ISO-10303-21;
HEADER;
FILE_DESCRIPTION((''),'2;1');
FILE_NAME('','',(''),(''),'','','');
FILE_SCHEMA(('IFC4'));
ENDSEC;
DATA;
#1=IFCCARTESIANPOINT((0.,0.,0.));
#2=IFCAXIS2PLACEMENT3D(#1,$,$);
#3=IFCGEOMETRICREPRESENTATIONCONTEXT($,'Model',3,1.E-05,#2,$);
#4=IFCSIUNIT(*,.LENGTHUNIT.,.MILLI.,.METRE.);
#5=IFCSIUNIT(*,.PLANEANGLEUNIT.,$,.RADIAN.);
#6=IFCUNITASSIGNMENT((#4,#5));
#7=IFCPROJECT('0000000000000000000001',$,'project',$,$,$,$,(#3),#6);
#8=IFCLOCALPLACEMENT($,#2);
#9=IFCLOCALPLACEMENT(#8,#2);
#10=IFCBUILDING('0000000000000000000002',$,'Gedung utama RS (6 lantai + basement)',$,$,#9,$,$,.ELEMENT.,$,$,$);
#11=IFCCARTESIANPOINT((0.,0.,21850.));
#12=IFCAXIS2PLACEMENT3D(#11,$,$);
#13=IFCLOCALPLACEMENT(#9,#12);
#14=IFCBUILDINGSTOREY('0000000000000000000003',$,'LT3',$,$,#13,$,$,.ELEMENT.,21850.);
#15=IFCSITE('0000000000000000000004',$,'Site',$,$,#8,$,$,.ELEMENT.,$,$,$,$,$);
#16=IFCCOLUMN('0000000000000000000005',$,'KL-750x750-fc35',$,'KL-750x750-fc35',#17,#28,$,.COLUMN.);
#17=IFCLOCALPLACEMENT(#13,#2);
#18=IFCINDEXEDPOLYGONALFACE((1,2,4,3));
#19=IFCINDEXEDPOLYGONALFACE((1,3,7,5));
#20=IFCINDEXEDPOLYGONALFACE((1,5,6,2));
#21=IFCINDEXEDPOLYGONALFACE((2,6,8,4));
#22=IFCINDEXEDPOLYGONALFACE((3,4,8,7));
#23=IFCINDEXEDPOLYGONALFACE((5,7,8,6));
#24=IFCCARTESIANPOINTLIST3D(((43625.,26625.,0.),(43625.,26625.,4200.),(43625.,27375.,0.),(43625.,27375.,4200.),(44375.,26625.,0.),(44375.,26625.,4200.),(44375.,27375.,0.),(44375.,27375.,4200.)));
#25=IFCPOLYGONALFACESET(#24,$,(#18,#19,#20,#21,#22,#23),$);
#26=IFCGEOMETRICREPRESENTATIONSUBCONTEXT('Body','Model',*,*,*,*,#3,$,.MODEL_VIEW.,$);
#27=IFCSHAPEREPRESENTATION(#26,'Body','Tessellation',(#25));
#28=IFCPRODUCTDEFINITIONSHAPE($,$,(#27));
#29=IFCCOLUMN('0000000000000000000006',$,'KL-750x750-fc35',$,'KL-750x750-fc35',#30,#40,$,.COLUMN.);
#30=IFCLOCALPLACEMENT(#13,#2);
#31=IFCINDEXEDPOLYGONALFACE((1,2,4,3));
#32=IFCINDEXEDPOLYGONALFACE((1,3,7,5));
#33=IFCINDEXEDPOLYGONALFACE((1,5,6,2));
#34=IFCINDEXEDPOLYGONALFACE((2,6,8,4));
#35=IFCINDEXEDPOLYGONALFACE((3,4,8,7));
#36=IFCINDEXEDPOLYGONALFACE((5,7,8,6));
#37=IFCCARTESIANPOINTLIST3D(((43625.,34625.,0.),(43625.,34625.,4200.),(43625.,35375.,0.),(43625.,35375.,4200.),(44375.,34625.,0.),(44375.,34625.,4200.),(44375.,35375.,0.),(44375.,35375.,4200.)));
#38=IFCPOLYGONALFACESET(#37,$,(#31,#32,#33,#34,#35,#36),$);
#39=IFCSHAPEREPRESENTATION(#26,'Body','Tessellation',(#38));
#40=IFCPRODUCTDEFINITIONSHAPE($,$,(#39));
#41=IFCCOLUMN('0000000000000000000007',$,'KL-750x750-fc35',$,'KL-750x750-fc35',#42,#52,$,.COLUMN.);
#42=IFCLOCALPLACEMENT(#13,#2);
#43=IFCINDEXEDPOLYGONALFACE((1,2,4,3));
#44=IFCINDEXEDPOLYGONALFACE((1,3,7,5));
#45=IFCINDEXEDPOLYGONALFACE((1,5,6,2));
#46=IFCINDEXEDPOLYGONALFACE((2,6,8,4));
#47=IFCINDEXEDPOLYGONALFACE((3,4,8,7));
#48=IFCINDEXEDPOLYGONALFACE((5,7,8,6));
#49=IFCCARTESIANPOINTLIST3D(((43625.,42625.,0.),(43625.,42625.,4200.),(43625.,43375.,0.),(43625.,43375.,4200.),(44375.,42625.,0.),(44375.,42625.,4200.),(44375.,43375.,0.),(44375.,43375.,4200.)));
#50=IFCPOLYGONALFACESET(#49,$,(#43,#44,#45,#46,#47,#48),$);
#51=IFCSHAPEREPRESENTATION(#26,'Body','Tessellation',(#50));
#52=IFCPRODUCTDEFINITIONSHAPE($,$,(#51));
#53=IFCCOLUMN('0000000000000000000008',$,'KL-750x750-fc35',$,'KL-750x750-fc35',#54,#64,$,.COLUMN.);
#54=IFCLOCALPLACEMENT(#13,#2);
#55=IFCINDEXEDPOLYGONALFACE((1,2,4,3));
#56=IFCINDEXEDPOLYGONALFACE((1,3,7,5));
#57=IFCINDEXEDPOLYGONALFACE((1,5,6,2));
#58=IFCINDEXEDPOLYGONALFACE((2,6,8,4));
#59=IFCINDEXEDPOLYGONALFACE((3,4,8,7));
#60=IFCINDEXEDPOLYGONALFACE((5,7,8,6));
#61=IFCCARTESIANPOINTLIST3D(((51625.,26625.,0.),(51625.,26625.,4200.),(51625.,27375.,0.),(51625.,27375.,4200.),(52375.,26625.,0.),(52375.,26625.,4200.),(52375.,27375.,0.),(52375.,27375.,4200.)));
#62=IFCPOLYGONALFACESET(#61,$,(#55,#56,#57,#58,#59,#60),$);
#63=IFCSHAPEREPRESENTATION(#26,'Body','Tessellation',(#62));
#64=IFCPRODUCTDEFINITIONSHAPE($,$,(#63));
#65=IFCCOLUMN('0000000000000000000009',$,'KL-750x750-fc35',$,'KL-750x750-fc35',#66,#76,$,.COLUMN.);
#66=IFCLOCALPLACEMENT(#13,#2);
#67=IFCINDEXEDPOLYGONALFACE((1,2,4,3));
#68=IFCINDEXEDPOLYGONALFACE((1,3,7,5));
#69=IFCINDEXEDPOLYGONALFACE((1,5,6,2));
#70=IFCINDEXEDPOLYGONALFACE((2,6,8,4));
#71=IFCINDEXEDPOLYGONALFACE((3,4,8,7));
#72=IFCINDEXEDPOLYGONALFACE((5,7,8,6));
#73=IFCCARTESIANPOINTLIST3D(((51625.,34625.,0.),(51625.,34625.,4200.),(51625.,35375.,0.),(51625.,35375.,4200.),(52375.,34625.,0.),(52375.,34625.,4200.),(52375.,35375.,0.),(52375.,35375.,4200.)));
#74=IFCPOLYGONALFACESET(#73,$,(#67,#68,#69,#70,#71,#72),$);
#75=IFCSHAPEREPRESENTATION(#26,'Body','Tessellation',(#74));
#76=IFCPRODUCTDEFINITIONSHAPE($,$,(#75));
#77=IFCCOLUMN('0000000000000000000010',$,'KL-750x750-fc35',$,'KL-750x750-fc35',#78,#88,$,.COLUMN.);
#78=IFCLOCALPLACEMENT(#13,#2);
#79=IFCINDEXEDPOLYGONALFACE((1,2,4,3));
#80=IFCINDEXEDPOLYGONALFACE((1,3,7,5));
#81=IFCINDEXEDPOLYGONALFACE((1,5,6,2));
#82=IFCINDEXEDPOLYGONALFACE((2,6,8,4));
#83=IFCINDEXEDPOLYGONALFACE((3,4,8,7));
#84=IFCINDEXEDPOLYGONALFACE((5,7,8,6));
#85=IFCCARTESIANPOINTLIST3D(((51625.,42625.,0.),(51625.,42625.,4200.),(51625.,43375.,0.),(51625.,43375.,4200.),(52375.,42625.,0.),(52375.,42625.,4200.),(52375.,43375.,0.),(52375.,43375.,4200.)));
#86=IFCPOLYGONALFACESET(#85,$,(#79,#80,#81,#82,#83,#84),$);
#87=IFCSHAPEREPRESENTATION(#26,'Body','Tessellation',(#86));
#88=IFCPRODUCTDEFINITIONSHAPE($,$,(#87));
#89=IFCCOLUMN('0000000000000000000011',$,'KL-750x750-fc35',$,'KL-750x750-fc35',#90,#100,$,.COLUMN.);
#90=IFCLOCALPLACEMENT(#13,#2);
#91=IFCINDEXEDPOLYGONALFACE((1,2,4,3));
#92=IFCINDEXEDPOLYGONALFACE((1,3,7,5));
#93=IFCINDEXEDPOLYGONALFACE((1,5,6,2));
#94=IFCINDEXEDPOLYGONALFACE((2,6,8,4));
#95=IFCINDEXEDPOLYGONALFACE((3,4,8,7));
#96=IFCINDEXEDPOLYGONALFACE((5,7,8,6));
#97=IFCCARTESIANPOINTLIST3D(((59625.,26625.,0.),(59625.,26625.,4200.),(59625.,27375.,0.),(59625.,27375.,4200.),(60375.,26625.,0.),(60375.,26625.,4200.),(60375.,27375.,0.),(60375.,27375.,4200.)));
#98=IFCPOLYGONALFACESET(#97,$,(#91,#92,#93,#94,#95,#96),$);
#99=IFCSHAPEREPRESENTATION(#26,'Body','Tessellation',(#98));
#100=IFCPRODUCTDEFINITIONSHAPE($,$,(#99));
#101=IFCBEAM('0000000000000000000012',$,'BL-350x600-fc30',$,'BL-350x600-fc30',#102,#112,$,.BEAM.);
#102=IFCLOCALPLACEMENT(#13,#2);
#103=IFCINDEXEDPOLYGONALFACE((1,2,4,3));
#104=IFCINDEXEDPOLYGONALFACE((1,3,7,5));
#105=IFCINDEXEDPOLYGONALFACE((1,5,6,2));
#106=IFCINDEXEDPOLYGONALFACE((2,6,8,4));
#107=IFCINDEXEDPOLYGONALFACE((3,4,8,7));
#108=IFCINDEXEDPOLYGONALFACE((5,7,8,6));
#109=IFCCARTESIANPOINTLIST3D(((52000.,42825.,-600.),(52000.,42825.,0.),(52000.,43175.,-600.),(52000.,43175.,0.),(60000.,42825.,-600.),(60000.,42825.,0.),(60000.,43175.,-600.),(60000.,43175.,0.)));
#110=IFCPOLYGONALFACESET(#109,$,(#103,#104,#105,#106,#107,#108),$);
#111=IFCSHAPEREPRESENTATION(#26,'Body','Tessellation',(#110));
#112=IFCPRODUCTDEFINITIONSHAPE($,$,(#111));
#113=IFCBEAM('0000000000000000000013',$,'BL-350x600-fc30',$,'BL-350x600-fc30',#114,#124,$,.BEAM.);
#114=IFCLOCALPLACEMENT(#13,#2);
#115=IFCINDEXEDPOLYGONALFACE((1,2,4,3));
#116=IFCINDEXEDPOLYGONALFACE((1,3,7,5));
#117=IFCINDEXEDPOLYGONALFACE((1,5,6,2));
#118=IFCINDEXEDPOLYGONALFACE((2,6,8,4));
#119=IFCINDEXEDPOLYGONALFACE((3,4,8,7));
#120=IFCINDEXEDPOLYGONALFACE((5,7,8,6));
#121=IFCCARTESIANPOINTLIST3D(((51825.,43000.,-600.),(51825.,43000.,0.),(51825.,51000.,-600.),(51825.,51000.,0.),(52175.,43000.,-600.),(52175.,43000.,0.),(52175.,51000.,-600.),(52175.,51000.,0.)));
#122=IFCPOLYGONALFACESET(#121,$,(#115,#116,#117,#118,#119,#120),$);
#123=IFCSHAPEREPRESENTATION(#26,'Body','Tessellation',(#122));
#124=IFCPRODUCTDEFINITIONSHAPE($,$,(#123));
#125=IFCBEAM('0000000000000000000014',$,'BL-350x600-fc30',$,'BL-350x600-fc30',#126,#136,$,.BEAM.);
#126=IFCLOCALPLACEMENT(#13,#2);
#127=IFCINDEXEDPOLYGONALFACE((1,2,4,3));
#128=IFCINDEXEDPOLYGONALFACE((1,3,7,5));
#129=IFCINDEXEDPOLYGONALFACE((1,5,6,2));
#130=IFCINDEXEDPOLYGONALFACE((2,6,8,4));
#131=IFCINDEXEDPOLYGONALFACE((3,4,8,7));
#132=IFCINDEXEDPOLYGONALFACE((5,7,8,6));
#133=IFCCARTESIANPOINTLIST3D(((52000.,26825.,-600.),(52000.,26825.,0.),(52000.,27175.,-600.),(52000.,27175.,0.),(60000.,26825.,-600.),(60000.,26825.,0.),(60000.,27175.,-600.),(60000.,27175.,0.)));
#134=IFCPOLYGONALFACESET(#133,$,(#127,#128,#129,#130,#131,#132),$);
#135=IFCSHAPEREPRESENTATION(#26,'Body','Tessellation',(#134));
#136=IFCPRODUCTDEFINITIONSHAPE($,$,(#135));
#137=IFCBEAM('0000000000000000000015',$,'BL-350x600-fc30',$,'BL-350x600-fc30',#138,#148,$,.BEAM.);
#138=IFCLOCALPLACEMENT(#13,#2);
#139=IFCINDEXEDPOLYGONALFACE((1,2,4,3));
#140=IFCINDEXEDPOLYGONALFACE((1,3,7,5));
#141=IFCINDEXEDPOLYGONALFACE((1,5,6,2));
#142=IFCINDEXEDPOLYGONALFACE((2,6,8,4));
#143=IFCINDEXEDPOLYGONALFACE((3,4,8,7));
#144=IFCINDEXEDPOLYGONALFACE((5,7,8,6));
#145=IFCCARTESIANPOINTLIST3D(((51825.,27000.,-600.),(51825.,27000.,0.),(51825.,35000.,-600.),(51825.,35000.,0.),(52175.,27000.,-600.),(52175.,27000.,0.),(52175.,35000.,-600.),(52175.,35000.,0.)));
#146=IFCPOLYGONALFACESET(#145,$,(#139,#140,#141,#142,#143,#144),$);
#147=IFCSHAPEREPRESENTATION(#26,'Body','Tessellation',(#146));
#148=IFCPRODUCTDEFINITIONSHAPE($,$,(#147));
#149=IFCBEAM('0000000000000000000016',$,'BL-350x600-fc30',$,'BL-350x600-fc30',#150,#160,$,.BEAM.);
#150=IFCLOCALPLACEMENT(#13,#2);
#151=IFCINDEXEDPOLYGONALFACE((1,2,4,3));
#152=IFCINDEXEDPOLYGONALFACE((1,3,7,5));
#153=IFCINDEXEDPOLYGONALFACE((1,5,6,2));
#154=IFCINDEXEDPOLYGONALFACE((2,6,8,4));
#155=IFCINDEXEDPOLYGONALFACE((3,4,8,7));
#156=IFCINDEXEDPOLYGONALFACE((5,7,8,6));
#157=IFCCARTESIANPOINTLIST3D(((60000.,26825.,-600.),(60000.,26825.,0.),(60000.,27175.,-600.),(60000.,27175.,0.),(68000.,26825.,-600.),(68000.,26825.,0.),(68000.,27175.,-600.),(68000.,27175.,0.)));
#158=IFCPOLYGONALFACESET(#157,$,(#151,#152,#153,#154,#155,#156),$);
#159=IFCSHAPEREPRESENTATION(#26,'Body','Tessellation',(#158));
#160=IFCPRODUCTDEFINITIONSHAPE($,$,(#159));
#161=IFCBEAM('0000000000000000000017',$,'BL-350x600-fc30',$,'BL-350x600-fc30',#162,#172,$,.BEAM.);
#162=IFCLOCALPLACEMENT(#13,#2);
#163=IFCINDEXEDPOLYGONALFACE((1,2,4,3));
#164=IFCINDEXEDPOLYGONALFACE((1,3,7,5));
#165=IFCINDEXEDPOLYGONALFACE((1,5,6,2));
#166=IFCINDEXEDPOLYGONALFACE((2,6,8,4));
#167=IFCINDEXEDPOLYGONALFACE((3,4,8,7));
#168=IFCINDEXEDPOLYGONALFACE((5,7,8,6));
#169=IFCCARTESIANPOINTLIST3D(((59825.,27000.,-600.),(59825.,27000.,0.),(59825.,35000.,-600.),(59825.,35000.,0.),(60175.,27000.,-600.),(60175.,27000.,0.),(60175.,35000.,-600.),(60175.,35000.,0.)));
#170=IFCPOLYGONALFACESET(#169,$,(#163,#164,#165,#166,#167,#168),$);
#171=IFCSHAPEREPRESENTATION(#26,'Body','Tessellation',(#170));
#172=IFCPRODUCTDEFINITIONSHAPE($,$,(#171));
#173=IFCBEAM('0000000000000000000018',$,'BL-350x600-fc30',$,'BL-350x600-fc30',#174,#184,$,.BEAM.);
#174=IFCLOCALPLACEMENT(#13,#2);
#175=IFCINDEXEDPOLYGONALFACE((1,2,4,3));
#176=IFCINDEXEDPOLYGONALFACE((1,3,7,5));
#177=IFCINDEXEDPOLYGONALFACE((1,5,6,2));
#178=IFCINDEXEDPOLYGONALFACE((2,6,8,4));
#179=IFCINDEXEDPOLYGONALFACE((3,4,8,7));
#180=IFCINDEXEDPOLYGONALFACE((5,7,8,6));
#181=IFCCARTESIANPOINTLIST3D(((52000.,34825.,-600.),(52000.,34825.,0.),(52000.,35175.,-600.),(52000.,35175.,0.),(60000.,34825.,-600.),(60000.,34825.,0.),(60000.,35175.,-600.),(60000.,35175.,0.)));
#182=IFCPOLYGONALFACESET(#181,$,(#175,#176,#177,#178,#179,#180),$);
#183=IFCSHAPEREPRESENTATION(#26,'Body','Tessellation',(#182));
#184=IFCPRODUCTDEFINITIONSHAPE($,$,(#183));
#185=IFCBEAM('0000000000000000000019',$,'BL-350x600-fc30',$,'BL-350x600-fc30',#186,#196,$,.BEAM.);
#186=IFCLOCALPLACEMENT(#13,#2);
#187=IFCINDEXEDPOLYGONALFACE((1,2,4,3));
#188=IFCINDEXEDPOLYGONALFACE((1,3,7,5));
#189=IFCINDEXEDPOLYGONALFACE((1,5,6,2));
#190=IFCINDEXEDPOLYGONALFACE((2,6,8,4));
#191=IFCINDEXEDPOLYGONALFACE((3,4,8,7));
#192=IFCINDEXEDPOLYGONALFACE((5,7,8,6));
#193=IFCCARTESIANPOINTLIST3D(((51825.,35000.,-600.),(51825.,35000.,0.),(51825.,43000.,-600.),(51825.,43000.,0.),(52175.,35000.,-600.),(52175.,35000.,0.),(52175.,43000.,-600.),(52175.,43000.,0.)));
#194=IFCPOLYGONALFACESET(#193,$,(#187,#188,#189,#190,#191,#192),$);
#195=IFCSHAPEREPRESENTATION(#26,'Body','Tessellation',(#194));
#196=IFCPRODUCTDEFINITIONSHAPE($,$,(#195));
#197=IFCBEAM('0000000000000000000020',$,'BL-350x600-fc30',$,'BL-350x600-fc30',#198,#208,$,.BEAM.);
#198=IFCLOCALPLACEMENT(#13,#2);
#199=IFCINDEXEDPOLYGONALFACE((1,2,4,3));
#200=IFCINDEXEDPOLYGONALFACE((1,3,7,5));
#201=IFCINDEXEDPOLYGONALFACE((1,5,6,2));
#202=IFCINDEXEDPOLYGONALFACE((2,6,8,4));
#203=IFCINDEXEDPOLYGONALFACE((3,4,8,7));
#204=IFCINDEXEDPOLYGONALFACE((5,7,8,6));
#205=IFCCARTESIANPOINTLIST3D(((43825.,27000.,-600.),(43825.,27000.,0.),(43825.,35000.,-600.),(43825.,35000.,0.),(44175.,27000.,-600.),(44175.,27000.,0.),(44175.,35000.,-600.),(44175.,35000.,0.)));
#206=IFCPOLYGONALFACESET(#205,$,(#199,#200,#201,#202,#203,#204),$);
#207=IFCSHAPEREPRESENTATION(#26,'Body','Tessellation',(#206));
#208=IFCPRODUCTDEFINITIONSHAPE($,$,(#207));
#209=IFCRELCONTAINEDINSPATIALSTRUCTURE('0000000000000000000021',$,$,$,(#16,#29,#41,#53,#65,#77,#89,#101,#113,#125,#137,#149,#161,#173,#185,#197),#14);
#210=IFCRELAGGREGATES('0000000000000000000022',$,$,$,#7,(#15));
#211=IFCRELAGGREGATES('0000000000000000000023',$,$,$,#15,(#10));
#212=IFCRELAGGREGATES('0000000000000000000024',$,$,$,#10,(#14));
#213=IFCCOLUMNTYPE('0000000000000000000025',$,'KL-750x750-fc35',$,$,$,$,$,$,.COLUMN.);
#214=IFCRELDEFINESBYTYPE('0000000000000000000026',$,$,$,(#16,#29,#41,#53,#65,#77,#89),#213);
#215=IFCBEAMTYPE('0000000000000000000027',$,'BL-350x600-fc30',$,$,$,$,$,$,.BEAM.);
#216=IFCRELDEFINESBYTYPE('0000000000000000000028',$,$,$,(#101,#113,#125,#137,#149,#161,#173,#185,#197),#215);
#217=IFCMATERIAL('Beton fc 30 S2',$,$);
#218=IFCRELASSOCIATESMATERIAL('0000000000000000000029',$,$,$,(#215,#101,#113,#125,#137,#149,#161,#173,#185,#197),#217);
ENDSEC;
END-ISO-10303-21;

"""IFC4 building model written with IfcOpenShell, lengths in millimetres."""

from ifc_helpers import new_model, si_unit, frame, origin, origin_2d, place, context, subcontext, project, spatial, rectangle, extrude, material, material_profile, profile_set, profile_usage, type_object, element, save


model = new_model("IFC4")

# Units and contexts
model_context = context("Model", 3, precision=1e-05, world=origin())
body_context = subcontext(model_context, "Body", "Model", "MODEL_VIEW")
ifc_project = project(units=[si_unit("LENGTHUNIT", "METRE", prefix="MILLI"), si_unit("PLANEANGLEUNIT", "RADIAN")], contexts=[model_context])

# Site, building, storey
site_placement = place(None, origin())
site = spatial("IfcSite", under=ifc_project, at=site_placement, Name="Site", CompositionType="ELEMENT")
building_placement = place(site_placement, origin())
building = spatial("IfcBuilding", under=site, at=building_placement, Name="Gedung utama RS (6 lantai + basement)", CompositionType="ELEMENT")
storey_placement = place(building_placement, frame((0.0, 0.0, 21850.0)))
storey = spatial("IfcBuildingStorey", under=building, at=storey_placement, Name="LT3", CompositionType="ELEMENT", Elevation=21850.0)

# Columns
ifc_material_profile_1 = material_profile(None, rectangle(XDim=750.0, YDim=750.0, at=origin_2d()), Name="KL-750x750-fc35")
ifc_profile_set_1 = profile_set([ifc_material_profile_1], Name="KL-750x750-fc35")
ifc_profile_usage_1 = profile_usage(ifc_profile_set_1, cardinal=5)
column_type = type_object("IfcColumnType", Name="KL-750x750-fc35", PredefinedType="COLUMN", material=ifc_profile_set_1)
for number, where, z_axis, x_axis, name in (
    (1, (44000.0, 27000.0, 0.0), (0.0, 0.0, 1.0), (1.0, 0.0, 0.0), "KL-750x750-fc35"),
    (2, (44000.0, 35000.0, 0.0), (0.0, 0.0, 1.0), (1.0, 0.0, 0.0), "KL-750x750-fc35"),
    (3, (44000.0, 43000.0, 0.0), (0.0, 0.0, 1.0), (1.0, 0.0, 0.0), "KL-750x750-fc35"),
    (4, (52000.0, 27000.0, 0.0), (0.0, 0.0, 1.0), (1.0, 0.0, 0.0), "KL-750x750-fc35"),
    (5, (52000.0, 35000.0, 0.0), (0.0, 0.0, 1.0), (1.0, 0.0, 0.0), "KL-750x750-fc35"),
    (6, (52000.0, 43000.0, 0.0), (0.0, 0.0, 1.0), (1.0, 0.0, 0.0), "KL-750x750-fc35"),
    (7, (60000.0, 27000.0, 0.0), (0.0, 0.0, 1.0), (1.0, 0.0, 0.0), "KL-750x750-fc35"),
):
    element("IfcColumn", number, at=place(storey_placement, frame(where, z_axis=z_axis, x_axis=x_axis)), inside=storey, type_object=column_type, material=ifc_profile_usage_1, Name=name, ObjectType="KL-750x750-fc35", PredefinedType="COLUMN", context=body_context, shape_type="SweptSolid", body=[
        extrude(rectangle(XDim=750.0, YDim=750.0, at=origin_2d()), origin(), (0.0, 0.0, 1.0), 4200.0),
    ])

# Beams
ifc_material_1 = material(Name="Beton fc 30 S2")
ifc_material_profile_2 = material_profile(ifc_material_1, rectangle(XDim=350.0, YDim=600.0, at=origin_2d()), Name="BL-350x600-fc30")
ifc_profile_set_2 = profile_set([ifc_material_profile_2], Name="BL-350x600-fc30")
ifc_profile_usage_2 = profile_usage(ifc_profile_set_2, cardinal=8)
beam_type = type_object("IfcBeamType", Name="BL-350x600-fc30", PredefinedType="BEAM", material=ifc_profile_set_2)
beam_1_placement = place(storey_placement, frame((52000.0, 43000.0, -300.0)))
element("IfcBeam", 8, at=beam_1_placement, inside=storey, type_object=beam_type, material=ifc_profile_usage_2, Name="BL-350x600-fc30", ObjectType="BL-350x600-fc30", PredefinedType="BEAM", context=body_context, shape_type="SweptSolid", body=[
    extrude(rectangle(XDim=350.0, YDim=600.0, at=origin_2d()), frame((0.0, 0.0, 0.0), z_axis=(1.0, 0.0, 0.0), x_axis=(0.0, 1.0, 0.0)), (0.0, 0.0, 1.0), 8000.0),
])
beam_2_placement = place(storey_placement, frame((52000.0, 43000.0, -300.0)))
element("IfcBeam", 9, at=beam_2_placement, inside=storey, type_object=beam_type, material=ifc_profile_usage_2, Name="BL-350x600-fc30", ObjectType="BL-350x600-fc30", PredefinedType="BEAM", context=body_context, shape_type="SweptSolid", body=[
    extrude(rectangle(XDim=350.0, YDim=600.0, at=origin_2d()), frame((0.0, 0.0, 0.0), z_axis=(0.0, 1.0, 0.0), x_axis=(-1.0, 0.0, 0.0)), (0.0, 0.0, 1.0), 8000.0),
])
beam_3_placement = place(storey_placement, frame((52000.0, 27000.0, -300.0)))
element("IfcBeam", 10, at=beam_3_placement, inside=storey, type_object=beam_type, material=ifc_profile_usage_2, Name="BL-350x600-fc30", ObjectType="BL-350x600-fc30", PredefinedType="BEAM", context=body_context, shape_type="SweptSolid", body=[
    extrude(rectangle(XDim=350.0, YDim=600.0, at=origin_2d()), frame((0.0, 0.0, 0.0), z_axis=(1.0, 0.0, 0.0), x_axis=(0.0, 1.0, 0.0)), (0.0, 0.0, 1.0), 8000.0),
])
beam_4_placement = place(storey_placement, frame((52000.0, 27000.0, -300.0)))
element("IfcBeam", 11, at=beam_4_placement, inside=storey, type_object=beam_type, material=ifc_profile_usage_2, Name="BL-350x600-fc30", ObjectType="BL-350x600-fc30", PredefinedType="BEAM", context=body_context, shape_type="SweptSolid", body=[
    extrude(rectangle(XDim=350.0, YDim=600.0, at=origin_2d()), frame((0.0, 0.0, 0.0), z_axis=(0.0, 1.0, 0.0), x_axis=(-1.0, 0.0, 0.0)), (0.0, 0.0, 1.0), 8000.0),
])
beam_5_placement = place(storey_placement, frame((60000.0, 27000.0, -300.0)))
element("IfcBeam", 12, at=beam_5_placement, inside=storey, type_object=beam_type, material=ifc_profile_usage_2, Name="BL-350x600-fc30", ObjectType="BL-350x600-fc30", PredefinedType="BEAM", context=body_context, shape_type="SweptSolid", body=[
    extrude(rectangle(XDim=350.0, YDim=600.0, at=origin_2d()), frame((0.0, 0.0, 0.0), z_axis=(1.0, 0.0, 0.0), x_axis=(0.0, 1.0, 0.0)), (0.0, 0.0, 1.0), 8000.0),
])
beam_6_placement = place(storey_placement, frame((60000.0, 27000.0, -300.0)))
element("IfcBeam", 13, at=beam_6_placement, inside=storey, type_object=beam_type, material=ifc_profile_usage_2, Name="BL-350x600-fc30", ObjectType="BL-350x600-fc30", PredefinedType="BEAM", context=body_context, shape_type="SweptSolid", body=[
    extrude(rectangle(XDim=350.0, YDim=600.0, at=origin_2d()), frame((0.0, 0.0, 0.0), z_axis=(0.0, 1.0, 0.0), x_axis=(-1.0, 0.0, 0.0)), (0.0, 0.0, 1.0), 8000.0),
])
beam_7_placement = place(storey_placement, frame((52000.0, 35000.0, -300.0)))
element("IfcBeam", 14, at=beam_7_placement, inside=storey, type_object=beam_type, material=ifc_profile_usage_2, Name="BL-350x600-fc30", ObjectType="BL-350x600-fc30", PredefinedType="BEAM", context=body_context, shape_type="SweptSolid", body=[
    extrude(rectangle(XDim=350.0, YDim=600.0, at=origin_2d()), frame((0.0, 0.0, 0.0), z_axis=(1.0, 0.0, 0.0), x_axis=(0.0, 1.0, 0.0)), (0.0, 0.0, 1.0), 8000.0),
])
for number, where, name in (
    (15, (52000.0, 35000.0, -300.0), "BL-350x600-fc30"),
    (16, (44000.0, 27000.0, -300.0), "BL-350x600-fc30"),
):
    element("IfcBeam", number, at=place(storey_placement, frame(where)), inside=storey, type_object=beam_type, material=ifc_profile_usage_2, Name=name, ObjectType="BL-350x600-fc30", PredefinedType="BEAM", context=body_context, shape_type="SweptSolid", body=[
        extrude(rectangle(XDim=350.0, YDim=600.0, at=origin_2d()), frame((0.0, 0.0, 0.0), z_axis=(0.0, 1.0, 0.0), x_axis=(-1.0, 0.0, 0.0)), (0.0, 0.0, 1.0), 8000.0),
    ])

save(model, "model.ifc")
